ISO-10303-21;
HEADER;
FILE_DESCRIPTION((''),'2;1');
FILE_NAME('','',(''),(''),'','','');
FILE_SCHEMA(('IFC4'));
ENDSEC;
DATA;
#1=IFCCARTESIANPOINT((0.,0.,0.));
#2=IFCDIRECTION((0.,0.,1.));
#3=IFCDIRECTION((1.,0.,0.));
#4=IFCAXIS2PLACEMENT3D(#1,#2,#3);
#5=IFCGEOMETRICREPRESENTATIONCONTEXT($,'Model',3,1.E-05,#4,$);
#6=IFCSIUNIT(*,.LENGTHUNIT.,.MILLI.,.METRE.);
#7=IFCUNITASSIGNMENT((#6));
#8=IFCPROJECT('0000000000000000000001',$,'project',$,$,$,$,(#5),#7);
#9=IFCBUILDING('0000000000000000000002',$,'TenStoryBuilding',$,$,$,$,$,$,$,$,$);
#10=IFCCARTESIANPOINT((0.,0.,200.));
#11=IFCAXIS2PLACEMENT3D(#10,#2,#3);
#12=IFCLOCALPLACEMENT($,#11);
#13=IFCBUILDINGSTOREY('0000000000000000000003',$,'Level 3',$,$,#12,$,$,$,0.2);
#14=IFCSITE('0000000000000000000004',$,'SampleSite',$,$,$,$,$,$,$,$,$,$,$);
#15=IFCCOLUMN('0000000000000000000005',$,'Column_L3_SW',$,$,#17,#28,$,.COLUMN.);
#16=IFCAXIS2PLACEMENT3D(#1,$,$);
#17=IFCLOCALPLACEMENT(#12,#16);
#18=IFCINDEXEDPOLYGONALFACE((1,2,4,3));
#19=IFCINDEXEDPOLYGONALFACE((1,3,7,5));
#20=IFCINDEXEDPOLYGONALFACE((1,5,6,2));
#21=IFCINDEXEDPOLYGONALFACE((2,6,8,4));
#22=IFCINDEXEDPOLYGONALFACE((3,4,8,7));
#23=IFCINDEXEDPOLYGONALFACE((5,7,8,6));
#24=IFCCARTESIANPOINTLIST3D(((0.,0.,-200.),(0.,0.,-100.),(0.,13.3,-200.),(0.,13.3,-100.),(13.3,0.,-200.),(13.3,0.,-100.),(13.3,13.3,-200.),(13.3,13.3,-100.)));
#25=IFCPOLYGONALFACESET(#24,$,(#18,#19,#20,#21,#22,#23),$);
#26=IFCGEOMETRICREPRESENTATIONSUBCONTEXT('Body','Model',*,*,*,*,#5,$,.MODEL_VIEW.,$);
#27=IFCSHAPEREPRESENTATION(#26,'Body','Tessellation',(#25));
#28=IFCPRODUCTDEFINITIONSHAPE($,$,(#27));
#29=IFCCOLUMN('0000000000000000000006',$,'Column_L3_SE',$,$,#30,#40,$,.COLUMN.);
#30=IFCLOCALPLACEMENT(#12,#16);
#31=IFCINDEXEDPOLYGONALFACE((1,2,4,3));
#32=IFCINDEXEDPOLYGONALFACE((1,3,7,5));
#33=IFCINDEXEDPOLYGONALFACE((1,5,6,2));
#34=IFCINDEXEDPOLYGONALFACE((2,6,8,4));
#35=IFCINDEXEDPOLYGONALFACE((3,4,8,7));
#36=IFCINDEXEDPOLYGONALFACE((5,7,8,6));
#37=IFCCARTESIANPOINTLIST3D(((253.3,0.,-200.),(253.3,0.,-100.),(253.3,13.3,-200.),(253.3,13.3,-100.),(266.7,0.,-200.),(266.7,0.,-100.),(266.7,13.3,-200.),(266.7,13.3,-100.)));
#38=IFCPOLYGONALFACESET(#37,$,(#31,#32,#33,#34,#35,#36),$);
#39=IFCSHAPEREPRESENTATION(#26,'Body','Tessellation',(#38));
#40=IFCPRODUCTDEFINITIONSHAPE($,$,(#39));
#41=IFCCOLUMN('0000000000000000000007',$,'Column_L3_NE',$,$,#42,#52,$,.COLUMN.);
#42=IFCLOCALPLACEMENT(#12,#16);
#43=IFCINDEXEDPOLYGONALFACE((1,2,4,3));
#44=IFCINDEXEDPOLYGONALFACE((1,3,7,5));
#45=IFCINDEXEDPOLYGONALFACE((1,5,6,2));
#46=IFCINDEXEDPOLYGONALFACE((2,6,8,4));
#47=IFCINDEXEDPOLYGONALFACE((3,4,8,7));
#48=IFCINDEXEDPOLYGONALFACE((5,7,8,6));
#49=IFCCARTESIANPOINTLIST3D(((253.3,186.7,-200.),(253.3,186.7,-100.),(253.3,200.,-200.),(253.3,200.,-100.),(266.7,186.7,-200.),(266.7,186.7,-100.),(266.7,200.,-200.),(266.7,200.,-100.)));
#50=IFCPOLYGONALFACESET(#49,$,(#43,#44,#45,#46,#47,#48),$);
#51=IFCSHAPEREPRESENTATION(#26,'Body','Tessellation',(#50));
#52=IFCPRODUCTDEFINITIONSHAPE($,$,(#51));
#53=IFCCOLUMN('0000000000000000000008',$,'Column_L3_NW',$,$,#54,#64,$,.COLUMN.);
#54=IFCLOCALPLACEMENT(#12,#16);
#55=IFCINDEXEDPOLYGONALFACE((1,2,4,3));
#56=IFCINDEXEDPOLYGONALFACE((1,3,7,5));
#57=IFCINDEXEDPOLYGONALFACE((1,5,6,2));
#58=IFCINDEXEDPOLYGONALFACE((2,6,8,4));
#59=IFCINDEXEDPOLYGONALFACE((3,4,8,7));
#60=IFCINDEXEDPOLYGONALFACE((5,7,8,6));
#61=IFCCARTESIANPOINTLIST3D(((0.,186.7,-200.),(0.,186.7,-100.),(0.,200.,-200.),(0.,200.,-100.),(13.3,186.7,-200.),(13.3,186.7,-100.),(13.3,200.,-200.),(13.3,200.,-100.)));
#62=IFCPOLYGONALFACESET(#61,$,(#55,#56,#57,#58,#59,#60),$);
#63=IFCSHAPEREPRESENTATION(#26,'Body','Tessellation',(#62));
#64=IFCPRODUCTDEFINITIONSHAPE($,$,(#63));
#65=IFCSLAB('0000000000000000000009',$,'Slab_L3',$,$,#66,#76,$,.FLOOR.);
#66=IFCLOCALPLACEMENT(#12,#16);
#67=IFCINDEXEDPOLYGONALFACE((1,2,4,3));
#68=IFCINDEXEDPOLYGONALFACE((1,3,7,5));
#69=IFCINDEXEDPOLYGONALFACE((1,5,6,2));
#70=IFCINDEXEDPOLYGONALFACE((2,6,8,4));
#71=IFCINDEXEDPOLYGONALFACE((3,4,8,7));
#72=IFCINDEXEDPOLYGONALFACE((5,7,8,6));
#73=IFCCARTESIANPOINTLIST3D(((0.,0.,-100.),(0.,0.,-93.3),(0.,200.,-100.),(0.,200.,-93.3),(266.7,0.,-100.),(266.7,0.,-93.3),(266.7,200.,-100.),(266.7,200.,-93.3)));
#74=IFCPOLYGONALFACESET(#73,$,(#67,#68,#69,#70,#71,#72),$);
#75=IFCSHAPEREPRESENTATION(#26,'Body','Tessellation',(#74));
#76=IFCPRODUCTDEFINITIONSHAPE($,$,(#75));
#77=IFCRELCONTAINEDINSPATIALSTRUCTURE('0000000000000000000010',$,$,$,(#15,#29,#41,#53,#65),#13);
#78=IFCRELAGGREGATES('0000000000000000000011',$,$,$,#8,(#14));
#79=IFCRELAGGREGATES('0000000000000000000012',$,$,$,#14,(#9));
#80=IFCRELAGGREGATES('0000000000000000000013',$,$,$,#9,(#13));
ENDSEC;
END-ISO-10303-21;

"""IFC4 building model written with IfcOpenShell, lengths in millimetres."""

from ifc_helpers import new_model, si_unit, frame, origin_with_axes, origin_2d, place, context, subcontext, project, spatial, indexed_curve, rectangle, outline, extrude, element, save


model = new_model("IFC4")

# Units and contexts
model_context = context("Model", 3, precision=1e-05, world=origin_with_axes())
body_context = subcontext(model_context, "Body", "Model", "MODEL_VIEW")
ifc_project = project(units=[si_unit("LENGTHUNIT", "METRE", prefix="MILLI")], contexts=[model_context])

# Site, building, storey
site = spatial("IfcSite", under=ifc_project, Name="SampleSite")
building = spatial("IfcBuilding", under=site, Name="TenStoryBuilding")
storey_placement = place(None, frame((0.0, 0.0, 200.0), z_axis=(0.0, 0.0, 1.0), x_axis=(1.0, 0.0, 0.0)))
storey = spatial("IfcBuildingStorey", under=building, at=storey_placement, Name="Level 3", Elevation=0.2)

# Columns
for number, where, z_axis, x_axis, name in (
    (1, (6.7, 6.7, -200.0), (0.0, 0.0, 1.0), (1.0, 0.0, 0.0), "Column_L3_SW"),
    (2, (260.0, 6.7, -200.0), (0.0, 0.0, 1.0), (1.0, 0.0, 0.0), "Column_L3_SE"),
    (3, (260.0, 193.3, -200.0), (0.0, 0.0, 1.0), (1.0, 0.0, 0.0), "Column_L3_NE"),
    (4, (6.7, 193.3, -200.0), (0.0, 0.0, 1.0), (1.0, 0.0, 0.0), "Column_L3_NW"),
):
    element("IfcColumn", number, at=place(storey_placement, frame(where, z_axis=z_axis, x_axis=x_axis)), inside=storey, Name=name, PredefinedType="COLUMN", context=body_context, shape_type="SweptSolid", body=[
        extrude(rectangle(XDim=13.3, YDim=13.3, at=origin_2d()), origin_with_axes(), (0.0, 0.0, 1.0), 100.0),
    ])

# Slab
slab_placement = place(storey_placement, frame((0.0, 0.0, -100.0), z_axis=(0.0, 0.0, 1.0), x_axis=(1.0, 0.0, 0.0)))
element("IfcSlab", 5, at=slab_placement, inside=storey, Name="Slab_L3", PredefinedType="FLOOR", context=body_context, shape_type="SweptSolid", body=[
    extrude(outline(indexed_curve([(0.0, 0.0), (266.7, 0.0), (266.7, 200.0), (0.0, 200.0), (0.0, 0.0)])), None, (0.0, 0.0, 1.0), 6.7),
])

save(model, "model.ifc")
